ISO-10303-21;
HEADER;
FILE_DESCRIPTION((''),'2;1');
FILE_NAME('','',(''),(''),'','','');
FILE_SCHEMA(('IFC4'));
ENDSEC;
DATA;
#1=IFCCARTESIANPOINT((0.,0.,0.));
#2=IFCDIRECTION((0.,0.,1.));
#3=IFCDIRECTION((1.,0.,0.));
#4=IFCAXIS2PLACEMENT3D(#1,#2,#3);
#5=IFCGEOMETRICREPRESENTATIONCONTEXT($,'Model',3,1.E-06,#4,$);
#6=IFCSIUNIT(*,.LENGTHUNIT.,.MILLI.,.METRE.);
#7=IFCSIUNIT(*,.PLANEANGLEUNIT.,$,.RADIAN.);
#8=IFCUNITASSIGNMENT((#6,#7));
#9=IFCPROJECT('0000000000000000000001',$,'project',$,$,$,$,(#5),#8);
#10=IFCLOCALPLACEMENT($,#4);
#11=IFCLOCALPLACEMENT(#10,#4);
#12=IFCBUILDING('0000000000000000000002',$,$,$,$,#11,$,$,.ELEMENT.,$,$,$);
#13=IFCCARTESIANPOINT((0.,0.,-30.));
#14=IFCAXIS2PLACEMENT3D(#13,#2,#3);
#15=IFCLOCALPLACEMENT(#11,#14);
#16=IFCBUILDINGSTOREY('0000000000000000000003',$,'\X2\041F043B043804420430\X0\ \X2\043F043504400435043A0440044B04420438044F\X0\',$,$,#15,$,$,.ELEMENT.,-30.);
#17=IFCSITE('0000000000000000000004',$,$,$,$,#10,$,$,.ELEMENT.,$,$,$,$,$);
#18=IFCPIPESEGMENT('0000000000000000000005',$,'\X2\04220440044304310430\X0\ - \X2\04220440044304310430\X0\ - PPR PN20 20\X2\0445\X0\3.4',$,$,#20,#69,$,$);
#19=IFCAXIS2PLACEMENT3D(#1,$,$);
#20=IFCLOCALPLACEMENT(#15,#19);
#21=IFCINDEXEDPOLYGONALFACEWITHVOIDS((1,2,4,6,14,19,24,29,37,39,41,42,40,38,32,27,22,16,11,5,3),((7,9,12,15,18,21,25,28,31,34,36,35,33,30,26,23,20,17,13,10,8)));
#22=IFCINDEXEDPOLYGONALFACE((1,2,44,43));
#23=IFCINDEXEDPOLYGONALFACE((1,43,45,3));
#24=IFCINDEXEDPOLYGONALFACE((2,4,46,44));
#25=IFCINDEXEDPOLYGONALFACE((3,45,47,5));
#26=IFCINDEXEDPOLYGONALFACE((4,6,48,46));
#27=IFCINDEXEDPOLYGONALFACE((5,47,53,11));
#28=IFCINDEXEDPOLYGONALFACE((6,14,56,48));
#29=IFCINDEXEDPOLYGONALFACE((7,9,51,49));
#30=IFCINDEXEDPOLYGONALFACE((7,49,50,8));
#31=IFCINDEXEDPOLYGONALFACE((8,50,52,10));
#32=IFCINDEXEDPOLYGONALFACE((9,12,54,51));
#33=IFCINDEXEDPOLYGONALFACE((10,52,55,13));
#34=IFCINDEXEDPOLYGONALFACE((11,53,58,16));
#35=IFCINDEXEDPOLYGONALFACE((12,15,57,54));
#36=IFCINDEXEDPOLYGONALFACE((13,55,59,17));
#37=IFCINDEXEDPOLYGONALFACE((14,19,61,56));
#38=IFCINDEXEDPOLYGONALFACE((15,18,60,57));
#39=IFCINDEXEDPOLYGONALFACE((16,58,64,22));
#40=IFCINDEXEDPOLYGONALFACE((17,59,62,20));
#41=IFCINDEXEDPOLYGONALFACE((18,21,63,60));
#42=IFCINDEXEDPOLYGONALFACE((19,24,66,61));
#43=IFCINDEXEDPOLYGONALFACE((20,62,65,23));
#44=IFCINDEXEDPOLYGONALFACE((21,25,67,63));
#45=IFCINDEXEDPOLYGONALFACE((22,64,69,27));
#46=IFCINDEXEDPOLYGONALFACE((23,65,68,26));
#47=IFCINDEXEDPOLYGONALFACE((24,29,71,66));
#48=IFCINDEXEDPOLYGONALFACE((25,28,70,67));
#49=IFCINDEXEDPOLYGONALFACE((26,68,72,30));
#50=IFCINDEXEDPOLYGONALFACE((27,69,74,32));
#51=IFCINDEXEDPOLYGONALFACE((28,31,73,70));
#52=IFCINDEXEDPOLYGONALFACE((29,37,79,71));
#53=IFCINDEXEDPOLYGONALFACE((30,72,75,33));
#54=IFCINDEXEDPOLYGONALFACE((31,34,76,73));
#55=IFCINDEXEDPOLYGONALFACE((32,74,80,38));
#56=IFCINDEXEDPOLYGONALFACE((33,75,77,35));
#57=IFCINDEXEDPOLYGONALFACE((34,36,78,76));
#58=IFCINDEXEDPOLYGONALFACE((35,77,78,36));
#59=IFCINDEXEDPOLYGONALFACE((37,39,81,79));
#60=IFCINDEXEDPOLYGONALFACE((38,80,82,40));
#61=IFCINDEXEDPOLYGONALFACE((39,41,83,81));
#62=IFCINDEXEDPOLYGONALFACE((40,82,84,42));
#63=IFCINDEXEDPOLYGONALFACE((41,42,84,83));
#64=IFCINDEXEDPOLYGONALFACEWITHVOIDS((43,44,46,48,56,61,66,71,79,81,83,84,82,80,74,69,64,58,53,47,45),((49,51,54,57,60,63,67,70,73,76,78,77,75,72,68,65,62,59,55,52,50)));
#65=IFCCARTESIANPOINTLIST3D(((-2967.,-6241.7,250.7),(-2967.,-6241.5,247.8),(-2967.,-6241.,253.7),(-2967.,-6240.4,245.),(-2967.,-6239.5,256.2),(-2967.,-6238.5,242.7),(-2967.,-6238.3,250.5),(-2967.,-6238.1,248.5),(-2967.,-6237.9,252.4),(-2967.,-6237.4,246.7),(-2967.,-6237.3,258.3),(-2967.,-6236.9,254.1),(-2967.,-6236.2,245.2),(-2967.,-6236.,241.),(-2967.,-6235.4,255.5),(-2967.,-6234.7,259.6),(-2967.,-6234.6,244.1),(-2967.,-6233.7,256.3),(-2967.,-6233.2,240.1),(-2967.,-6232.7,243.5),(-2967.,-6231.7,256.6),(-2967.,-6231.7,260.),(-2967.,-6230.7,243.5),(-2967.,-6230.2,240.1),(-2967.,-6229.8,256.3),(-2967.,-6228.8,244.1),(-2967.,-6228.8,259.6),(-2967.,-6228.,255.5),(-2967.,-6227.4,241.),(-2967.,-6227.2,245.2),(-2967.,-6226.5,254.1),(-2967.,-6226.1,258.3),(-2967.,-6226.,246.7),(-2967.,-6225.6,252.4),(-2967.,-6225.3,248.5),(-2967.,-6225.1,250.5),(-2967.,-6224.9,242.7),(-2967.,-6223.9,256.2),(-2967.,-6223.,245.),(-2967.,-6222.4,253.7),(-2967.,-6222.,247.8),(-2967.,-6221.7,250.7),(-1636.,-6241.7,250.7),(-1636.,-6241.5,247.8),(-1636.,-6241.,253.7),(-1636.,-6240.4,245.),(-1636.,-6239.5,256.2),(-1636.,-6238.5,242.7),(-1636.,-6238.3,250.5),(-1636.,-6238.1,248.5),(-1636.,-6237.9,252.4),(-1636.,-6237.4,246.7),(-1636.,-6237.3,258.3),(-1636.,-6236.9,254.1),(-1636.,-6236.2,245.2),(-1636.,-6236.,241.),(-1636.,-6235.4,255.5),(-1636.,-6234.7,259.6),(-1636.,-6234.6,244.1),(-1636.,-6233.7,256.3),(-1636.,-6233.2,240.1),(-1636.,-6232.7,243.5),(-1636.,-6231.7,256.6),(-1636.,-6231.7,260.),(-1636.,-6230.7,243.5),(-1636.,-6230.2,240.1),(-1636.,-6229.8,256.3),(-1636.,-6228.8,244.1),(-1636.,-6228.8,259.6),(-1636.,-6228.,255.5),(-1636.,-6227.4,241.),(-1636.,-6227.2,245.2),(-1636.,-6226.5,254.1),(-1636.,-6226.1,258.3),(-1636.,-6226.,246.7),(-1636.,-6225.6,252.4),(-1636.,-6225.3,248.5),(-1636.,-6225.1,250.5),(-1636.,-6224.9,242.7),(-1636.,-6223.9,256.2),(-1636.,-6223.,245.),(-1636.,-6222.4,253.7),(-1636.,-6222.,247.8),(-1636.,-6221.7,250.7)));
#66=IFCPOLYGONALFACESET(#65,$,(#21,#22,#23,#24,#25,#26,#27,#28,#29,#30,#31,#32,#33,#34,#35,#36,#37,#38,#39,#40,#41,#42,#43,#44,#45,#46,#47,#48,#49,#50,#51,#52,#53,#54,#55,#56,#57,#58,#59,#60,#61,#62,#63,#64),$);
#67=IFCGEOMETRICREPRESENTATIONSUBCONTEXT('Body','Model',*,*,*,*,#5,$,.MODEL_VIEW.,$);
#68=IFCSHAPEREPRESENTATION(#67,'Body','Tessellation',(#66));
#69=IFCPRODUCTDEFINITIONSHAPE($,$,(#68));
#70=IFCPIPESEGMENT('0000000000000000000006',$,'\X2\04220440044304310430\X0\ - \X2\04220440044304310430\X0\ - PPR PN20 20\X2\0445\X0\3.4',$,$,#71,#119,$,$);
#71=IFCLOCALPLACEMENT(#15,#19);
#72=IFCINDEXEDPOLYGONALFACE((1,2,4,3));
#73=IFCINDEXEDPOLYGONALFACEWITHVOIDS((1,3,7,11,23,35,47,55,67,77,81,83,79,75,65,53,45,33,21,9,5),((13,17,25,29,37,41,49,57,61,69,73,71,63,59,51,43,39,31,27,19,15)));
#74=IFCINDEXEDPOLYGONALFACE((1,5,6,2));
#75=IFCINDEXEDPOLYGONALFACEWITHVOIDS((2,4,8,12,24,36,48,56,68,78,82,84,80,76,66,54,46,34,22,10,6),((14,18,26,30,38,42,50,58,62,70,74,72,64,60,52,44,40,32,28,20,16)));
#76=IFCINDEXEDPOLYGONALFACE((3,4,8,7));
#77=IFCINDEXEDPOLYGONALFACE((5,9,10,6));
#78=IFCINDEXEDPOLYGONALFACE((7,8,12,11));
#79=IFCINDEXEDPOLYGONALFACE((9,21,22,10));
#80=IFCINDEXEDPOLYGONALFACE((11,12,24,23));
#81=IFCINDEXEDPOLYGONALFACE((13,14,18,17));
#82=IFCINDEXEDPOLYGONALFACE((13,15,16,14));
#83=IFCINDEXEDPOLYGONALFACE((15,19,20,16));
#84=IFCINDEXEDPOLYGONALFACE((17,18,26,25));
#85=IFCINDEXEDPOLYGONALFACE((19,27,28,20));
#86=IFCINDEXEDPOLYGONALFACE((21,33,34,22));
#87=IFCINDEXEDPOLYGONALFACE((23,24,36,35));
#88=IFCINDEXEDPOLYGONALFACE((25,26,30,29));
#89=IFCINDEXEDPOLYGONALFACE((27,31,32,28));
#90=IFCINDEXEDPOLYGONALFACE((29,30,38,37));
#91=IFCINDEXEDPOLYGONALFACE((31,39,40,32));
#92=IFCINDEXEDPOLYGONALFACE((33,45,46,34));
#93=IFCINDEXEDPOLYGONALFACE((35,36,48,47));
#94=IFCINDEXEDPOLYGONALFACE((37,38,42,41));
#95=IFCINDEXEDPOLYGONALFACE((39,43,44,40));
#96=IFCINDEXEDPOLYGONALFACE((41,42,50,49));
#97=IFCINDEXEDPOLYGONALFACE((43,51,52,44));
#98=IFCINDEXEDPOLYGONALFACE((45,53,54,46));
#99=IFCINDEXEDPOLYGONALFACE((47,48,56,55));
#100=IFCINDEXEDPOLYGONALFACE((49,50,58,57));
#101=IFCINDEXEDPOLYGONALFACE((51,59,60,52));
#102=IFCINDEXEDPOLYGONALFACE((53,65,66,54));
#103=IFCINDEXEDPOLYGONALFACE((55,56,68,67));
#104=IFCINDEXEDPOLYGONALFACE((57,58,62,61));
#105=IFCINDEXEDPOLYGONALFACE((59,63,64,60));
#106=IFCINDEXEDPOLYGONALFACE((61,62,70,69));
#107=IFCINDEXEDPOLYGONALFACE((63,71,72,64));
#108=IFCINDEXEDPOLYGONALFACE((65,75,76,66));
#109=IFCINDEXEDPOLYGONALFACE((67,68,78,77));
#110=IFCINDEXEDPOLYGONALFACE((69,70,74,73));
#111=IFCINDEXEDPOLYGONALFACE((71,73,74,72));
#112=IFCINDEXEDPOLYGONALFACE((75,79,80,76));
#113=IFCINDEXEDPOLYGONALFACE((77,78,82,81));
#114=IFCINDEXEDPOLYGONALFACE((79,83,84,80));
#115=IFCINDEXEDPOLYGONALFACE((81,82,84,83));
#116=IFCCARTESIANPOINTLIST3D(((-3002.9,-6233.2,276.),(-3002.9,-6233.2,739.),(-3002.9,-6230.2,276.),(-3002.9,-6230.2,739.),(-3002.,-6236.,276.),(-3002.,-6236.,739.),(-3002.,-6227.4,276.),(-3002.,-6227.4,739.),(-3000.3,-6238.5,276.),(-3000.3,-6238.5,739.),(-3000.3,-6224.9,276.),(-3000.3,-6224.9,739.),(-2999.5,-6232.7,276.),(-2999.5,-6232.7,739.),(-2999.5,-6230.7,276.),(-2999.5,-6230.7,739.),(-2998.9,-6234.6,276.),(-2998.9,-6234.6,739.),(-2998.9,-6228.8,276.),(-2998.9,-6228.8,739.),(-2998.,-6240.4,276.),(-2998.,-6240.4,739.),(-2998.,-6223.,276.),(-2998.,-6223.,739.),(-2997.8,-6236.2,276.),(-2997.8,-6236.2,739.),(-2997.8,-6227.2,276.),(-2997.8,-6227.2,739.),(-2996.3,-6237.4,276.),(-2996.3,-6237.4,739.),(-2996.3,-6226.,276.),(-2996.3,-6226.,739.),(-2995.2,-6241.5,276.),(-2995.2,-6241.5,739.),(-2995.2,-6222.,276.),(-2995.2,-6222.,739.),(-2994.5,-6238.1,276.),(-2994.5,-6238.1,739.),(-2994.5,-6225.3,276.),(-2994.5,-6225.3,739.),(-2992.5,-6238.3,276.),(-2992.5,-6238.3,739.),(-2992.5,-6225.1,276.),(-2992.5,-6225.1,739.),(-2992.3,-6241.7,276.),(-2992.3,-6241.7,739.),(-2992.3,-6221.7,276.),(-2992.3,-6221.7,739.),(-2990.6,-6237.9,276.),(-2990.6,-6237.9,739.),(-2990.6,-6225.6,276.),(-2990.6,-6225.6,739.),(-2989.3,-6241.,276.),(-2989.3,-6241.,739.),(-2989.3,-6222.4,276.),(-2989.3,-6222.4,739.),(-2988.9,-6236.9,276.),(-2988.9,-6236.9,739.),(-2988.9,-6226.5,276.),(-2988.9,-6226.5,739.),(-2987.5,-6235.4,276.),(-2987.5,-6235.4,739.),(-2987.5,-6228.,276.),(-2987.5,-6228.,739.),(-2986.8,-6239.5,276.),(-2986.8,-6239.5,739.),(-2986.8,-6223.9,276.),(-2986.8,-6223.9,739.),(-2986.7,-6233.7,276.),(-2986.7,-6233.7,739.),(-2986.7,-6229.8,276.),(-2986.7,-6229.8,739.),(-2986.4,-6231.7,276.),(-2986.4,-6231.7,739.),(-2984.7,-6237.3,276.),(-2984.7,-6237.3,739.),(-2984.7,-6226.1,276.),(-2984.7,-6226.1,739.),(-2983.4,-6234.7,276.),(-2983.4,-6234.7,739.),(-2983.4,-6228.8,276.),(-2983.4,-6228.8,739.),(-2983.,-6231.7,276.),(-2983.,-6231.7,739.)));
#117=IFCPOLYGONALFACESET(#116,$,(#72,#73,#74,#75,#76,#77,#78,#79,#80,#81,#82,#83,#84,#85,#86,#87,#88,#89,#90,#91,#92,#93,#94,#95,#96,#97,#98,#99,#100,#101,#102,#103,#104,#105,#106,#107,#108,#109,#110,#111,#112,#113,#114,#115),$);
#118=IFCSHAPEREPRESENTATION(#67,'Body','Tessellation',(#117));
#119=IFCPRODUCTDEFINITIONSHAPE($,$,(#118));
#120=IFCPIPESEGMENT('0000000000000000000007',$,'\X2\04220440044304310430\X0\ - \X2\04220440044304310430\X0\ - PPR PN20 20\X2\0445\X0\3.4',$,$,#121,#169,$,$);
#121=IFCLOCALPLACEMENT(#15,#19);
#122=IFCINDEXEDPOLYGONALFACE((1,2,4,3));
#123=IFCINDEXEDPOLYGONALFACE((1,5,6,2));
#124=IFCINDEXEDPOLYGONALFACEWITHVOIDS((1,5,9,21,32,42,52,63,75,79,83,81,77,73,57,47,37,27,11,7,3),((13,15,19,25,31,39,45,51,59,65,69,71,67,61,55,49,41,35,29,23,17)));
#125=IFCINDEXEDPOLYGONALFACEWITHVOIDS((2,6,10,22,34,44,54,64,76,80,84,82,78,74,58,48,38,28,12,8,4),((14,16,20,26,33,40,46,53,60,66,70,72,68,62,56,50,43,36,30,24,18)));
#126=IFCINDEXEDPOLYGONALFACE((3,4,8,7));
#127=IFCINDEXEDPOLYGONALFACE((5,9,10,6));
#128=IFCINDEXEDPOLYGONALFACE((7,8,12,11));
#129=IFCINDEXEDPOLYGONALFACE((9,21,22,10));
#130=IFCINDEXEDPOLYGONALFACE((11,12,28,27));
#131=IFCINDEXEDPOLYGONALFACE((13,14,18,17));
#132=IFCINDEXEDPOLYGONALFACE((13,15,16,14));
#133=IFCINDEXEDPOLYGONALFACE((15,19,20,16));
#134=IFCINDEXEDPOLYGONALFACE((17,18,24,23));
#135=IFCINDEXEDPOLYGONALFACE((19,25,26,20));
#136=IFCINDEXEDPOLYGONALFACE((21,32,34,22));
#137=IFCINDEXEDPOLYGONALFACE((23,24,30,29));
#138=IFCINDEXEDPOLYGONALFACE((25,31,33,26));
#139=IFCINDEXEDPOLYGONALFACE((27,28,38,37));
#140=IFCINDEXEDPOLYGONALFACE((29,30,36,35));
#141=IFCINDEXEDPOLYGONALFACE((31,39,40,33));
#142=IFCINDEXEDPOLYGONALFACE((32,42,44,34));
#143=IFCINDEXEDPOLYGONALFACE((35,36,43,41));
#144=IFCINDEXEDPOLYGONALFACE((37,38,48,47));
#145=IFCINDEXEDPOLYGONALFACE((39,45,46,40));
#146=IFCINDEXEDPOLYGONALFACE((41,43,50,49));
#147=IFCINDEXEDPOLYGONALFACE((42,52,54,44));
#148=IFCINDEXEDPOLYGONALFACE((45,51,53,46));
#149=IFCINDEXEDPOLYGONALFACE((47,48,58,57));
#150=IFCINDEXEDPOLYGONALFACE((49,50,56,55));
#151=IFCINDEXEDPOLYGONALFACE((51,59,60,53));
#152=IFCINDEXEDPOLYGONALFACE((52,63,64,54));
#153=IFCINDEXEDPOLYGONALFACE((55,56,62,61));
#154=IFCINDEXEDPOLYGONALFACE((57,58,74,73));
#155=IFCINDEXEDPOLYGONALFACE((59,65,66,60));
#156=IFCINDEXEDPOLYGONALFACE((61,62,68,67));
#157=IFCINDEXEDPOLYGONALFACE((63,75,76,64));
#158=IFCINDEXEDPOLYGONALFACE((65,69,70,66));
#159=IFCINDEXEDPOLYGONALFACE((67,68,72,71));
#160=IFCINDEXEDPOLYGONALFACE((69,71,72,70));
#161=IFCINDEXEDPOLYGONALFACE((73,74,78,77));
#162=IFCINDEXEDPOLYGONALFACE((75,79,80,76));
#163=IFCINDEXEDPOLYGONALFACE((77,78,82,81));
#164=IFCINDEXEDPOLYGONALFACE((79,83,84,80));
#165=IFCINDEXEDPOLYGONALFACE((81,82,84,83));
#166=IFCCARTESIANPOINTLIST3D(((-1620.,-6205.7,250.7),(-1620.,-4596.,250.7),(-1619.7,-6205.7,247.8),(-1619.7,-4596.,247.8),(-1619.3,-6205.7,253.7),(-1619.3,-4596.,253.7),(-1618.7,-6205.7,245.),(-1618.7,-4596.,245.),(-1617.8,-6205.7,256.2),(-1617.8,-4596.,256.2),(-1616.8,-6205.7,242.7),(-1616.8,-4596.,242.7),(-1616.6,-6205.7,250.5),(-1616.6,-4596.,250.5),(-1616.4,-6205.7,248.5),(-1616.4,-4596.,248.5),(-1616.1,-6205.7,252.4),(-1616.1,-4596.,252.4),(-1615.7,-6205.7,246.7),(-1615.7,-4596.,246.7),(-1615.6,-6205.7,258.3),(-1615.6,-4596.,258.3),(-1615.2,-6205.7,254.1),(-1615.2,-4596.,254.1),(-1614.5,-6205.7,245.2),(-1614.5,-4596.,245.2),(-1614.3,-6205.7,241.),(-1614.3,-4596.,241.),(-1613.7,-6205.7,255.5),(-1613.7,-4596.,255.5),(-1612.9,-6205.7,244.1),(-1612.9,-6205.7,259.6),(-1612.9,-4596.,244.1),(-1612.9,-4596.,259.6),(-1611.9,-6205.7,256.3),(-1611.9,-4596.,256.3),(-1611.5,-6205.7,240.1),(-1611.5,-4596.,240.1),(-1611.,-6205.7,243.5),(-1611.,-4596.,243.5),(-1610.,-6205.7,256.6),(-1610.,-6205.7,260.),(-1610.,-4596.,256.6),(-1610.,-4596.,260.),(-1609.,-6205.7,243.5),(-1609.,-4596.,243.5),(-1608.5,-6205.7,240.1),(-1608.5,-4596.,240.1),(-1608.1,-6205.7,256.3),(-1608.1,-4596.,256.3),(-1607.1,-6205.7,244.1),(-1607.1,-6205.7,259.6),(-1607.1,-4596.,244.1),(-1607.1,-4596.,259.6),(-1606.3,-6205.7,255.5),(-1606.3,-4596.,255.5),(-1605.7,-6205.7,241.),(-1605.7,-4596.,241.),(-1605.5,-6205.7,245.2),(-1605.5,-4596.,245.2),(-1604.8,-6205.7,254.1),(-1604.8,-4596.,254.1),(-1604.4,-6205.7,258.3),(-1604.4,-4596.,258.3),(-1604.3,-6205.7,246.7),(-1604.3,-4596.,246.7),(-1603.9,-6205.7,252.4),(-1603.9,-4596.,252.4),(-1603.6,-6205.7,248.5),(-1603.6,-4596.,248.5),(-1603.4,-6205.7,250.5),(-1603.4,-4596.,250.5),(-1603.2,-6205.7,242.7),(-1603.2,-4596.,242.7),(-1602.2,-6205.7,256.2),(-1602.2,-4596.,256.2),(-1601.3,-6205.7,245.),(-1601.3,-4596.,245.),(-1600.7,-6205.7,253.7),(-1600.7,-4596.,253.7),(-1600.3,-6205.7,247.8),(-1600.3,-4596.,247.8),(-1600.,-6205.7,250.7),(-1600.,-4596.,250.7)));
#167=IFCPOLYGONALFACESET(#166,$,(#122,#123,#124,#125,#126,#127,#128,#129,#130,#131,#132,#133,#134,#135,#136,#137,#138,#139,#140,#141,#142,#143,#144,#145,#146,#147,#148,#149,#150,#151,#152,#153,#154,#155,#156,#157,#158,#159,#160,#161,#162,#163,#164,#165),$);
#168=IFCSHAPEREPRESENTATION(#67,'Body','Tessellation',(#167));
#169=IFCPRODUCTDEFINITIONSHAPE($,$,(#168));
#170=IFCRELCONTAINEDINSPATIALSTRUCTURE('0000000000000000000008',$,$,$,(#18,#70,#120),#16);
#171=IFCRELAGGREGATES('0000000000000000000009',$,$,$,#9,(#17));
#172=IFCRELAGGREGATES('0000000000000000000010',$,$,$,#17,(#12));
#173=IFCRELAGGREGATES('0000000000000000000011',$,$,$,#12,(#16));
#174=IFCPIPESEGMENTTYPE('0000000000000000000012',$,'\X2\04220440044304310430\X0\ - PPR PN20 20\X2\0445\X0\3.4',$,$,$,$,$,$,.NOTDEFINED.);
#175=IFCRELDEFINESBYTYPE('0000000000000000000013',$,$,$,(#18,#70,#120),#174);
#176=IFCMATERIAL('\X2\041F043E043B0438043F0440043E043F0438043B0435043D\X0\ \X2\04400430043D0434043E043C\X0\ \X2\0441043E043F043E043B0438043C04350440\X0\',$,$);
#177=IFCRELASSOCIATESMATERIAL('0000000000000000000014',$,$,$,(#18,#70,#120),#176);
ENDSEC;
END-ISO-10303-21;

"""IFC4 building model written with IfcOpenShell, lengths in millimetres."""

from ifc_helpers import new_model, entity, si_unit, frame, origin_with_axes, place, context, subcontext, project, spatial, material, type_object, element, save


model = new_model("IFC4")

# Units and contexts
model_context = context("Model", 3, precision=1e-06, world=origin_with_axes())
body_context = subcontext(model_context, "Body", "Model", "MODEL_VIEW")
ifc_project = project(units=[si_unit("LENGTHUNIT", "METRE", prefix="MILLI"), si_unit("PLANEANGLEUNIT", "RADIAN")], contexts=[model_context])

# Site, building, storey
site_placement = place(None, origin_with_axes())
site = spatial("IfcSite", under=ifc_project, at=site_placement, CompositionType="ELEMENT")
building_placement = place(site_placement, origin_with_axes())
building = spatial("IfcBuilding", under=site, at=building_placement, CompositionType="ELEMENT")
storey_placement = place(building_placement, frame((0.0, 0.0, -30.0), z_axis=(0.0, 0.0, 1.0), x_axis=(1.0, 0.0, 0.0)))
storey = spatial("IfcBuildingStorey", under=building, at=storey_placement, Name="Плита перекрытия", CompositionType="ELEMENT", Elevation=-30.0)

# Pipe segments
ifc_material_1 = material(Name="Полипропилен рандом сополимер")
pipe_segment_type_1 = type_object("IfcPipeSegmentType", Name="Труба - PPR PN20 20х3.4", PredefinedType="NOTDEFINED")
pipe_segment_1_placement = place(storey_placement, frame((-2967.0, -6231.7, 250.0), z_axis=(0.0, 0.0, 1.0), x_axis=(1.0, 0.0, 0.0)))
element("IfcPipeSegment", 1, at=pipe_segment_1_placement, inside=storey, type_object=pipe_segment_type_1, material=ifc_material_1, Name="Труба - Труба - PPR PN20 20х3.4", context=body_context, shape_type="AdvancedSweptSolid", body=[
    entity("IfcSweptDiskSolid", entity("IfcIndexedPolyCurve", entity("IfcCartesianPointList3D", [[0.0, 0.0, 0.0], [1331.0, 0.0, 0.0]]), [entity("IfcLineIndex", [1, 2])]), 10.0, 6.6),
])
pipe_segment_2_placement = place(storey_placement, frame((-2993.0, -6231.7, 739.0), z_axis=(0.0, 0.0, 1.0), x_axis=(-1.0, 0.0, 0.0)))
element("IfcPipeSegment", 2, at=pipe_segment_2_placement, inside=storey, type_object=pipe_segment_type_1, material=ifc_material_1, Name="Труба - Труба - PPR PN20 20х3.4", context=body_context, shape_type="AdvancedSweptSolid", body=[
    entity("IfcSweptDiskSolid", entity("IfcIndexedPolyCurve", entity("IfcCartesianPointList3D", [[0.0, 0.0, 0.0], [0.0, 0.0, -463.0]]), [entity("IfcLineIndex", [1, 2])]), 10.0, 6.6),
])
pipe_segment_3_placement = place(storey_placement, frame((-1610.0, -6205.7, 250.0), z_axis=(0.0, 0.0, 1.0), x_axis=(0.0, 1.0, 0.0)))
element("IfcPipeSegment", 3, at=pipe_segment_3_placement, inside=storey, type_object=pipe_segment_type_1, material=ifc_material_1, Name="Труба - Труба - PPR PN20 20х3.4", context=body_context, shape_type="AdvancedSweptSolid", body=[
    entity("IfcSweptDiskSolid", entity("IfcIndexedPolyCurve", entity("IfcCartesianPointList3D", [[0.0, 0.0, 0.0], [1609.7, 0.0, 0.0]]), [entity("IfcLineIndex", [1, 2])]), 10.0, 6.6),
])

save(model, "model.ifc")
